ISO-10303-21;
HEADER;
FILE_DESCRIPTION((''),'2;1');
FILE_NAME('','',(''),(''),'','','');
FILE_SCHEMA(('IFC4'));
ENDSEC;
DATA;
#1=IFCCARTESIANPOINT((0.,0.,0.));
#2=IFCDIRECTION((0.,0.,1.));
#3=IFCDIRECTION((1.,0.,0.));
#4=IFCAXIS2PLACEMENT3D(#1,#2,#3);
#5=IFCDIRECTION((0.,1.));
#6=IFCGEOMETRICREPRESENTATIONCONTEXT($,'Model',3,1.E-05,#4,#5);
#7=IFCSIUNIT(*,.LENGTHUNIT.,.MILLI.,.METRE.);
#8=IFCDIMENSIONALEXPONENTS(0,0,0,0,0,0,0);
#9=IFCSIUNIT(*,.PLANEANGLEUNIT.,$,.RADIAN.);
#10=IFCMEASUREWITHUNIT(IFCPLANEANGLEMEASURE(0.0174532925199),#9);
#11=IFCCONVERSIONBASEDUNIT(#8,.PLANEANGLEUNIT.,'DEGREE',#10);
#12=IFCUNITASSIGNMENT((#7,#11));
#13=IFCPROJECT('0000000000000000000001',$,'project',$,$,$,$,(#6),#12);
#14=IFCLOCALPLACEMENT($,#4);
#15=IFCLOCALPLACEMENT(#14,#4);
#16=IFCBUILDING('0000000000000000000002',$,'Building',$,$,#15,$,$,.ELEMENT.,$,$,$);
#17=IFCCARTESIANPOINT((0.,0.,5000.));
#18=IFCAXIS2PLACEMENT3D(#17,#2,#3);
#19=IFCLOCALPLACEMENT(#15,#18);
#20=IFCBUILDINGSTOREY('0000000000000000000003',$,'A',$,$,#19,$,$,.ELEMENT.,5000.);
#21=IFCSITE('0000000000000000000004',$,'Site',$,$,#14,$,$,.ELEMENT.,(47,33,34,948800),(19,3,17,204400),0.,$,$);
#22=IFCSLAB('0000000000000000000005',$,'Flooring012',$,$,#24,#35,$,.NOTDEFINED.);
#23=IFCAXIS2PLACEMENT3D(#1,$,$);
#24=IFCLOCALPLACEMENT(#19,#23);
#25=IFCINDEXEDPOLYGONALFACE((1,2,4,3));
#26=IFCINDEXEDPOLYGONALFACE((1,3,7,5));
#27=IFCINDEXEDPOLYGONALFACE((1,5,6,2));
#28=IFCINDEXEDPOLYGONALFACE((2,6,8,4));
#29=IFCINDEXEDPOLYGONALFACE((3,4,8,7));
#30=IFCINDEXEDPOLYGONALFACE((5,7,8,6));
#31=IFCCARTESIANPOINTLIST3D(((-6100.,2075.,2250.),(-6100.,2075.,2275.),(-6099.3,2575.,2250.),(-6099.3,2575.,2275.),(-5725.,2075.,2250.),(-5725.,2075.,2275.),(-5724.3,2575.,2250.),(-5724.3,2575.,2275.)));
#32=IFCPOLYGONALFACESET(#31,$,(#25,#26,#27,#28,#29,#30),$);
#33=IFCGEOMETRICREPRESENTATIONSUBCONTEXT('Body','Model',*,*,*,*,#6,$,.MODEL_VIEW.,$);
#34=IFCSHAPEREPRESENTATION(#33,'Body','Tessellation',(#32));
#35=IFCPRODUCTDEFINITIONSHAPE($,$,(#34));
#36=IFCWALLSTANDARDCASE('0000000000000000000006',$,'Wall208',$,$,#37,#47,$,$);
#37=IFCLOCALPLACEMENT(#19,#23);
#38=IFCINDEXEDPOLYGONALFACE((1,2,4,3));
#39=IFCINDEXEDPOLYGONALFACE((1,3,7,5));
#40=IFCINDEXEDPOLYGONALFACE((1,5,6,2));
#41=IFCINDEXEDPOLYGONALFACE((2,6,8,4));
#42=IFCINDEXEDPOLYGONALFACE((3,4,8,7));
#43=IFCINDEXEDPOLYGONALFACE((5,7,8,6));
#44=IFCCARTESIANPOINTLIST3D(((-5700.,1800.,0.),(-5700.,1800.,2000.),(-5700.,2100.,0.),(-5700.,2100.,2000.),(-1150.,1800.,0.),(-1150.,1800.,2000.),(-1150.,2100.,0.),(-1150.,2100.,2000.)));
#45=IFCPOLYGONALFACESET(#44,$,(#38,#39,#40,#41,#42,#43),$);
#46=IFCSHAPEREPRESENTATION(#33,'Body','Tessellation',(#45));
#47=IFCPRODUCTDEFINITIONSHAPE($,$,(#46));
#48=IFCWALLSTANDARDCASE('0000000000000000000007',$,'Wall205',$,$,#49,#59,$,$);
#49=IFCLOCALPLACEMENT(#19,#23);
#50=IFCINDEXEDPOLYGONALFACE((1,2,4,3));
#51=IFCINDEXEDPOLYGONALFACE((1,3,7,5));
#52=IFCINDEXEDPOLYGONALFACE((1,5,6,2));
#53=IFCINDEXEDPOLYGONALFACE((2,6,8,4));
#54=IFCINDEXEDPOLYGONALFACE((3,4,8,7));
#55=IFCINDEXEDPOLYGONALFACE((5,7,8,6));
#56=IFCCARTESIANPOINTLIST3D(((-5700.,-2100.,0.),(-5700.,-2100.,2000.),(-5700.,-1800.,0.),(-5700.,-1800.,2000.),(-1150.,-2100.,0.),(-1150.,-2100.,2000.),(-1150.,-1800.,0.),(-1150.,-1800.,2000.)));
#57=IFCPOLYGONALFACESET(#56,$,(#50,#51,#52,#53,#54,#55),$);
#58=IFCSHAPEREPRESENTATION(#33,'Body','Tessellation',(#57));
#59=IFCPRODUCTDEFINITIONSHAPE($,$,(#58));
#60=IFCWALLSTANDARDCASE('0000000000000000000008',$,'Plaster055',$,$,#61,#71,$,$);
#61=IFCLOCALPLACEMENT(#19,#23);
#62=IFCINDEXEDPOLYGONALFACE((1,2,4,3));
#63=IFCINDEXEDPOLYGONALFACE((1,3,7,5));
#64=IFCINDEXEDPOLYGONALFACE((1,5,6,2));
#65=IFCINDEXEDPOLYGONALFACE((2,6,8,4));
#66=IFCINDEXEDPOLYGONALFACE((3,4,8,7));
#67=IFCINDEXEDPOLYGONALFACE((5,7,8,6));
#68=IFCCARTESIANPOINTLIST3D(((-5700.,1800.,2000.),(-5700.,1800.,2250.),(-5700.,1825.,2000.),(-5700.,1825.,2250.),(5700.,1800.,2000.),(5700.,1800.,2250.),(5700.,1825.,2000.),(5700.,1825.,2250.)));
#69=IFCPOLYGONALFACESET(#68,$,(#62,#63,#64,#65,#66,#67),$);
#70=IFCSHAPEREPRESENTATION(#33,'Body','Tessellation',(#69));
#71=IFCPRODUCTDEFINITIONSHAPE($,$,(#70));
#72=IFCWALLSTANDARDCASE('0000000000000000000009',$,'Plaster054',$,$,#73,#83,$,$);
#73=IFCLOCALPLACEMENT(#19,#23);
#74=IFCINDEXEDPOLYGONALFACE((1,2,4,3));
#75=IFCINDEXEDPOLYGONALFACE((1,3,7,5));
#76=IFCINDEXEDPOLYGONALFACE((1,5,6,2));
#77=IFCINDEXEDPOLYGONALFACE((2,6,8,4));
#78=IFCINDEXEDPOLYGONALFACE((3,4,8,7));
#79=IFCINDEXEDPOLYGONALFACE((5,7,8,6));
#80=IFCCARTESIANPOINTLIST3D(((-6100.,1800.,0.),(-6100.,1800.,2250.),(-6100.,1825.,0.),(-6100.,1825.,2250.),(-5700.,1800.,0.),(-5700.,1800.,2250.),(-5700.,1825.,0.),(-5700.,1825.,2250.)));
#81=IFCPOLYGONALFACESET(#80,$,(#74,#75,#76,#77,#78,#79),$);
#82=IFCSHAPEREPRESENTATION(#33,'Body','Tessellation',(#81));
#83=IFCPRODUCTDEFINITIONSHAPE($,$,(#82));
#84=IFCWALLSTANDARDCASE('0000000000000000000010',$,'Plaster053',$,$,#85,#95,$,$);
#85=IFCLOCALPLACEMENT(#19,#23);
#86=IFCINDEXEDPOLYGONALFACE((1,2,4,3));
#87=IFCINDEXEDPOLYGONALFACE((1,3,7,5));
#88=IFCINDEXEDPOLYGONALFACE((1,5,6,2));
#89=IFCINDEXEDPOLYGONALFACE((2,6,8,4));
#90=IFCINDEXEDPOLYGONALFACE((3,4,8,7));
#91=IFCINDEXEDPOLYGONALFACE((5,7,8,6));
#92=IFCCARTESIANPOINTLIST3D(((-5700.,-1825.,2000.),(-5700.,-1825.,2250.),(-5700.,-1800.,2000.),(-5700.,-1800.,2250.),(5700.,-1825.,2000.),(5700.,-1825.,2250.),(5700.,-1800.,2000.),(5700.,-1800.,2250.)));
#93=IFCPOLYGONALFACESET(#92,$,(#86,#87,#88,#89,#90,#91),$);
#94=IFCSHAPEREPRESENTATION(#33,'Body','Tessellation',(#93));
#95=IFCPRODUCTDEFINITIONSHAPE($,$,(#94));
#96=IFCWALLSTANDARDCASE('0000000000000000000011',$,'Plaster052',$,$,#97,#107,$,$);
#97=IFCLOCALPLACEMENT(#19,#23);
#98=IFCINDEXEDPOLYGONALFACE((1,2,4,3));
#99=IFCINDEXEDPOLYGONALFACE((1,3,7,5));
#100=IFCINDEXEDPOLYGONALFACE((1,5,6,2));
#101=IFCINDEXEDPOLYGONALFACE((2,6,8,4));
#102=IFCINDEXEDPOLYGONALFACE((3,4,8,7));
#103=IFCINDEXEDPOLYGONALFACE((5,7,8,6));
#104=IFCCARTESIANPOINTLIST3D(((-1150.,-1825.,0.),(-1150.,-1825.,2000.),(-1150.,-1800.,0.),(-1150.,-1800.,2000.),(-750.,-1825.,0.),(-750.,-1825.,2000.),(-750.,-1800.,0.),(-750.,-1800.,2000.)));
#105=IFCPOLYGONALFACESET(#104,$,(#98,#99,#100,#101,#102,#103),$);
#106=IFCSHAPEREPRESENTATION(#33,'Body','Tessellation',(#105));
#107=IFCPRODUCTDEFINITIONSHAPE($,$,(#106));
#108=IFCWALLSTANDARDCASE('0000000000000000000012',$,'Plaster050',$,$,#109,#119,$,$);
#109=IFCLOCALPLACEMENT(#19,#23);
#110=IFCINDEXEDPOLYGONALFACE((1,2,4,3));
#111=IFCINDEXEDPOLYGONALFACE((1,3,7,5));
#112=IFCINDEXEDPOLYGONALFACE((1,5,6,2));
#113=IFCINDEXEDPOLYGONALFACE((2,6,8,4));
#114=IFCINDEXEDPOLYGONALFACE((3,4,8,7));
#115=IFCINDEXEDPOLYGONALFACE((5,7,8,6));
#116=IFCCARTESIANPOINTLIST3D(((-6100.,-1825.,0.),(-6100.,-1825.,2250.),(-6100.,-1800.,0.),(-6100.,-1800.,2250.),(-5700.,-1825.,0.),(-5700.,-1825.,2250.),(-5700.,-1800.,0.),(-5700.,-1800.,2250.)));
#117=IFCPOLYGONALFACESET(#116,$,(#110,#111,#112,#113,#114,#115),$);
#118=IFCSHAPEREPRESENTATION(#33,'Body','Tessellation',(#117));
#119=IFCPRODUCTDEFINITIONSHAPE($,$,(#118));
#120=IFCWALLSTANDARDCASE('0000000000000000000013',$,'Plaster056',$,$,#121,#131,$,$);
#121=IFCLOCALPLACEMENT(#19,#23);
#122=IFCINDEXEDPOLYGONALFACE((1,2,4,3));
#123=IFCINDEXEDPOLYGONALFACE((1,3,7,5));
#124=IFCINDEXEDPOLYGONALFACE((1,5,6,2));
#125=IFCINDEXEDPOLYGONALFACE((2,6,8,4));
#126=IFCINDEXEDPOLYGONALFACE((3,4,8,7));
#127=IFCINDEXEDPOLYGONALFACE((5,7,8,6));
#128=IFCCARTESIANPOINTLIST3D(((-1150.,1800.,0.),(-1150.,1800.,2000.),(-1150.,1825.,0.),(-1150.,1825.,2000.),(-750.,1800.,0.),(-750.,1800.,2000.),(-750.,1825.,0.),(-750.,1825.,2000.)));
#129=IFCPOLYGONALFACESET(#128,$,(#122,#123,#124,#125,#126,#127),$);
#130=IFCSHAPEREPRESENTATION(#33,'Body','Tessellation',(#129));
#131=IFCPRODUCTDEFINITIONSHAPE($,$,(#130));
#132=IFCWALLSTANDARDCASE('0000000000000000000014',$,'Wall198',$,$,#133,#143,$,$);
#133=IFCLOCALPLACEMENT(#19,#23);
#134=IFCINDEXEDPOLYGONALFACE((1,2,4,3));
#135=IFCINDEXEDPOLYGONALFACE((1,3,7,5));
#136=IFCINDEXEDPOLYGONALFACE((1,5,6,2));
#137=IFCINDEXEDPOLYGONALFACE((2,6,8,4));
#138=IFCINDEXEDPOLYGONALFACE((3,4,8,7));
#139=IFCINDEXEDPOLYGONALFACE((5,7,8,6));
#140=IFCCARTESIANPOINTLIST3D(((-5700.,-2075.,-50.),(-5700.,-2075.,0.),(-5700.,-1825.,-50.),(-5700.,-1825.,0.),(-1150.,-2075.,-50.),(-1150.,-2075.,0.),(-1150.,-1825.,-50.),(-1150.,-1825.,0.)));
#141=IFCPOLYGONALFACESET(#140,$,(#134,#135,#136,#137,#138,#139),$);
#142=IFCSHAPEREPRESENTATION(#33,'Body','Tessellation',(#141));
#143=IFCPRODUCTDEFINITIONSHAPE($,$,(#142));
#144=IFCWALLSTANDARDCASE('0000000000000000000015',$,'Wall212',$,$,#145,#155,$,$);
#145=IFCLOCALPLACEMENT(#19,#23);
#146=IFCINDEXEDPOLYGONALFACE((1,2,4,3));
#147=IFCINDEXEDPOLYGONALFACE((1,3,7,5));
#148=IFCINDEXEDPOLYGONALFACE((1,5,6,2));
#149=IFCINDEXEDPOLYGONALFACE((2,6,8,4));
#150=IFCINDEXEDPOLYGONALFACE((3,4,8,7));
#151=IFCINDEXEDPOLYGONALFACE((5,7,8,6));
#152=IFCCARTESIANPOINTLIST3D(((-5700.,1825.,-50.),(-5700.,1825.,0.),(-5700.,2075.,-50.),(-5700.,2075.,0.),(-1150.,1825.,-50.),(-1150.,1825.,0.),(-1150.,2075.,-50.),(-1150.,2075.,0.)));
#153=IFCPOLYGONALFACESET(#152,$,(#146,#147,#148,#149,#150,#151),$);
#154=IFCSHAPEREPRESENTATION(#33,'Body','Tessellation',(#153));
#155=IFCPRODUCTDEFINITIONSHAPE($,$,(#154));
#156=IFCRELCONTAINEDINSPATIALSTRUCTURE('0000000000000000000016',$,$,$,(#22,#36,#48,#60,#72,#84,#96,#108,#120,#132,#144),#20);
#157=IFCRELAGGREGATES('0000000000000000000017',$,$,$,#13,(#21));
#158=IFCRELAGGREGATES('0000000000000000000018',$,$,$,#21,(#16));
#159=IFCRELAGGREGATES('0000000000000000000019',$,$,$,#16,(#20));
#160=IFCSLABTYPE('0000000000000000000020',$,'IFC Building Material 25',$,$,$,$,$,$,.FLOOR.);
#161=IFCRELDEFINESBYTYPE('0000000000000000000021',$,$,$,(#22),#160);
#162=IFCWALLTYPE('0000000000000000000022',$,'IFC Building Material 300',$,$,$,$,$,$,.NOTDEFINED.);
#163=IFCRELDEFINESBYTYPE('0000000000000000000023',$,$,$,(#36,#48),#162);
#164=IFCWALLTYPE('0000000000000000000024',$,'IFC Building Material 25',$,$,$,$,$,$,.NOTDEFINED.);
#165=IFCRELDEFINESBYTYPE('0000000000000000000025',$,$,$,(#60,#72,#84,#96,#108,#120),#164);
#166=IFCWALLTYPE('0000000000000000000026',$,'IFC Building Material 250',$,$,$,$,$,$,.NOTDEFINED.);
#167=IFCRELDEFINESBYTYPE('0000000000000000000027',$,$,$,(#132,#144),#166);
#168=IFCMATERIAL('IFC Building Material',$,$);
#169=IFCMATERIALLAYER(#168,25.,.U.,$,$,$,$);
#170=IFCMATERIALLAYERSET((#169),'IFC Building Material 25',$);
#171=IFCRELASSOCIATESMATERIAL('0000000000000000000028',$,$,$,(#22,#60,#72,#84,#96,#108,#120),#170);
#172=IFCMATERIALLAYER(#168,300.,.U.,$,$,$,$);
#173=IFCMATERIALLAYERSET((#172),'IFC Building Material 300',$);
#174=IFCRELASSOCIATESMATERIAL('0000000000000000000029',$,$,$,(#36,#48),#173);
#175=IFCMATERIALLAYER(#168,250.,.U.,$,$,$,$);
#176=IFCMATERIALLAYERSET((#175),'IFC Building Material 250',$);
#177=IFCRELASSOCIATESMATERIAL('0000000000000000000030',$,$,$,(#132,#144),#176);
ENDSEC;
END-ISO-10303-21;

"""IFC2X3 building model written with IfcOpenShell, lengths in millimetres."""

from ifc_helpers import new_model, entity, si_unit, converted_unit, direction, frame, origin_with_axes, place, context, subcontext, project, spatial, polyline, outline, extrude, material, layer, layer_set, layer_usage, type_object, element, save


model = new_model("IFC2X3")

# Units and contexts
model_context = context("Model", 3, precision=1e-05, world=origin_with_axes(), true_north=direction((0.0, 1.0)))
body_context = subcontext(model_context, "Body", "Model", "MODEL_VIEW")
ifc_project = project(units=[si_unit("LENGTHUNIT", "METRE", prefix="MILLI"), converted_unit("PLANEANGLEUNIT", "DEGREE", entity("IfcPlaneAngleMeasure", 0.0174532925199), si_unit("PLANEANGLEUNIT", "RADIAN"), dimensions=[0, 0, 0, 0, 0, 0, 0])], contexts=[model_context])

# Site, building, storey
site_placement = place(None, origin_with_axes())
site = spatial("IfcSite", under=ifc_project, at=site_placement, Name="Site", CompositionType="ELEMENT", RefLatitude=(47, 33, 34, 948800), RefLongitude=(19, 3, 17, 204400), RefElevation=0.0)
building_placement = place(site_placement, origin_with_axes())
building = spatial("IfcBuilding", under=site, at=building_placement, Name="Building", CompositionType="ELEMENT")
storey_placement = place(building_placement, frame((0.0, 0.0, 5000.0), z_axis=(0.0, 0.0, 1.0), x_axis=(1.0, 0.0, 0.0)))
storey = spatial("IfcBuildingStorey", under=building, at=storey_placement, Name="A", CompositionType="ELEMENT", Elevation=5000.0)

# Shared definitions
ifc_material = material(Name="IFC Building Material")

# Slab
ifc_layer_1 = layer(ifc_material, 250.0, ventilated="UNKNOWN")
ifc_layer_set_1 = layer_set([ifc_layer_1], Name="IFC Building Material 250")
ifc_layer_2 = layer(ifc_material, 25.0, ventilated="UNKNOWN")
ifc_layer_set_2 = layer_set([ifc_layer_2], Name="IFC Building Material 25")
slab_type_1 = type_object("IfcSlabType", Name="IFC Building Material 25", PredefinedType="FLOOR")
ifc_layer_usage_1 = layer_usage(ifc_layer_set_2, "AXIS3", "NEGATIVE", 25.0)
slab_1_placement = place(storey_placement, frame((-6099.3, 2575.0, 2275.0), z_axis=(0.0, 0.0, 1.0), x_axis=(1.0, 0.0, 0.0)))
element("IfcSlab", 1, at=slab_1_placement, inside=storey, type_object=slab_type_1, material=ifc_layer_usage_1, Name="Flooring012", PredefinedType="NOTDEFINED", context=body_context, shape_type="SweptSolid", body=[
    extrude(outline(polyline([(0.0, 0.0), (-0.7, -500.0), (374.3, -500.0), (375.0, 0.0), (0.0, 0.0)])), frame((0.0, 0.0, -25.0), z_axis=(0.0, 0.0, 1.0), x_axis=(1.0, 0.0, 0.0)), (0.0, 0.0, 1.0), 25.0),
])

# Walls
ifc_layer_3 = layer(ifc_material, 300.0, ventilated="UNKNOWN")
ifc_layer_set_3 = layer_set([ifc_layer_3], Name="IFC Building Material 300")
ifc_layer_usage_2 = layer_usage(ifc_layer_set_3, "AXIS2", "NEGATIVE", 0.0)
wall_type_1 = type_object("IfcWallType", Name="IFC Building Material 300", PredefinedType="NOTDEFINED")
wall_1_placement = place(storey_placement, frame((-1150.0, 1800.0, 0.0), z_axis=(0.0, 0.0, 1.0), x_axis=(-1.0, 0.0, 0.0)))
element("IfcWallStandardCase", 2, at=wall_1_placement, inside=storey, type_object=wall_type_1, material=ifc_layer_usage_2, Name="Wall208", context=body_context, shape_type="SweptSolid", body=[
    extrude(outline(polyline([(0.0, -300.0), (4550.0, -300.0), (4550.0, 0.0), (0.0, 0.0), (0.0, -300.0)])), origin_with_axes(), (0.0, 0.0, 1.0), 2000.0),
])
ifc_layer_usage_3 = layer_usage(ifc_layer_set_3, "AXIS2", "NEGATIVE", 300.0)
wall_2_placement = place(storey_placement, frame((-1150.0, -1800.0, 0.0), z_axis=(0.0, 0.0, 1.0), x_axis=(-1.0, 0.0, 0.0)))
element("IfcWallStandardCase", 3, at=wall_2_placement, inside=storey, type_object=wall_type_1, material=ifc_layer_usage_3, Name="Wall205", context=body_context, shape_type="SweptSolid", body=[
    extrude(outline(polyline([(0.0, 0.0), (4550.0, 0.0), (4550.0, 300.0), (0.0, 300.0), (0.0, 0.0)])), origin_with_axes(), (0.0, 0.0, 1.0), 2000.0),
])
ifc_layer_usage_4 = layer_usage(ifc_layer_set_2, "AXIS2", "POSITIVE", 0.0)
wall_type_2 = type_object("IfcWallType", Name="IFC Building Material 25", PredefinedType="NOTDEFINED")
wall_3_placement = place(storey_placement, frame((-5700.0, 1800.0, 2000.0), z_axis=(0.0, 0.0, 1.0), x_axis=(1.0, 0.0, 0.0)))
element("IfcWallStandardCase", 4, at=wall_3_placement, inside=storey, type_object=wall_type_2, material=ifc_layer_usage_4, Name="Plaster055", context=body_context, shape_type="SweptSolid", body=[
    extrude(outline(polyline([(0.0, 0.0), (11400.0, 0.0), (11400.0, 25.0), (0.0, 25.0), (0.0, 0.0)])), origin_with_axes(), (0.0, 0.0, 1.0), 250.0),
])
ifc_layer_usage_5 = layer_usage(ifc_layer_set_2, "AXIS2", "POSITIVE", 0.0)
wall_4_placement = place(storey_placement, frame((-6100.0, 1800.0, 0.0), z_axis=(0.0, 0.0, 1.0), x_axis=(1.0, 0.0, 0.0)))
element("IfcWallStandardCase", 5, at=wall_4_placement, inside=storey, type_object=wall_type_2, material=ifc_layer_usage_5, Name="Plaster054", context=body_context, shape_type="SweptSolid", body=[
    extrude(outline(polyline([(0.0, 0.0), (400.0, 0.0), (400.0, 25.0), (0.0, 25.0), (0.0, 0.0)])), origin_with_axes(), (0.0, 0.0, 1.0), 2250.0),
])
ifc_layer_usage_6 = layer_usage(ifc_layer_set_2, "AXIS2", "POSITIVE", -25.0)
wall_5_placement = place(storey_placement, frame((-5700.0, -1800.0, 2000.0), z_axis=(0.0, 0.0, 1.0), x_axis=(1.0, 0.0, 0.0)))
element("IfcWallStandardCase", 6, at=wall_5_placement, inside=storey, type_object=wall_type_2, material=ifc_layer_usage_6, Name="Plaster053", context=body_context, shape_type="SweptSolid", body=[
    extrude(outline(polyline([(0.0, -25.0), (11400.0, -25.0), (11400.0, 0.0), (0.0, 0.0), (0.0, -25.0)])), origin_with_axes(), (0.0, 0.0, 1.0), 250.0),
])
ifc_layer_usage_7 = layer_usage(ifc_layer_set_2, "AXIS2", "POSITIVE", -25.0)
wall_6_placement = place(storey_placement, frame((-1150.0, -1800.0, 0.0), z_axis=(0.0, 0.0, 1.0), x_axis=(1.0, 0.0, 0.0)))
element("IfcWallStandardCase", 7, at=wall_6_placement, inside=storey, type_object=wall_type_2, material=ifc_layer_usage_7, Name="Plaster052", context=body_context, shape_type="SweptSolid", body=[
    extrude(outline(polyline([(0.0, -25.0), (400.0, -25.0), (400.0, 0.0), (0.0, 0.0), (0.0, -25.0)])), origin_with_axes(), (0.0, 0.0, 1.0), 2000.0),
])
ifc_layer_usage_8 = layer_usage(ifc_layer_set_2, "AXIS2", "POSITIVE", -25.0)
wall_7_placement = place(storey_placement, frame((-6100.0, -1800.0, 0.0), z_axis=(0.0, 0.0, 1.0), x_axis=(1.0, 0.0, 0.0)))
element("IfcWallStandardCase", 8, at=wall_7_placement, inside=storey, type_object=wall_type_2, material=ifc_layer_usage_8, Name="Plaster050", context=body_context, shape_type="SweptSolid", body=[
    extrude(outline(polyline([(0.0, -25.0), (400.0, -25.0), (400.0, 0.0), (0.0, 0.0), (0.0, -25.0)])), origin_with_axes(), (0.0, 0.0, 1.0), 2250.0),
])
ifc_layer_usage_9 = layer_usage(ifc_layer_set_2, "AXIS2", "POSITIVE", 0.0)
wall_8_placement = place(storey_placement, frame((-1150.0, 1800.0, 0.0), z_axis=(0.0, 0.0, 1.0), x_axis=(1.0, 0.0, 0.0)))
element("IfcWallStandardCase", 9, at=wall_8_placement, inside=storey, type_object=wall_type_2, material=ifc_layer_usage_9, Name="Plaster056", context=body_context, shape_type="SweptSolid", body=[
    extrude(outline(polyline([(0.0, 0.0), (400.0, 0.0), (400.0, 25.0), (0.0, 25.0), (0.0, 0.0)])), origin_with_axes(), (0.0, 0.0, 1.0), 2000.0),
])
ifc_layer_usage_10 = layer_usage(ifc_layer_set_1, "AXIS2", "POSITIVE", -250.0)
wall_type_3 = type_object("IfcWallType", Name="IFC Building Material 250", PredefinedType="NOTDEFINED")
wall_9_placement = place(storey_placement, frame((-1150.0, -2075.0, -50.0), z_axis=(0.0, 0.0, 1.0), x_axis=(-1.0, 0.0, 0.0)))
element("IfcWallStandardCase", 10, at=wall_9_placement, inside=storey, type_object=wall_type_3, material=ifc_layer_usage_10, Name="Wall198", context=body_context, shape_type="SweptSolid", body=[
    extrude(outline(polyline([(0.0, -250.0), (4550.0, -250.0), (4550.0, 0.0), (0.0, 0.0), (0.0, -250.0)])), origin_with_axes(), (0.0, 0.0, 1.0), 50.0),
])
ifc_layer_usage_11 = layer_usage(ifc_layer_set_1, "AXIS2", "POSITIVE", 0.0)
wall_10_placement = place(storey_placement, frame((-1150.0, 2075.0, -50.0), z_axis=(0.0, 0.0, 1.0), x_axis=(-1.0, 0.0, 0.0)))
element("IfcWallStandardCase", 11, at=wall_10_placement, inside=storey, type_object=wall_type_3, material=ifc_layer_usage_11, Name="Wall212", context=body_context, shape_type="SweptSolid", body=[
    extrude(outline(polyline([(0.0, 0.0), (4550.0, 0.0), (4550.0, 250.0), (0.0, 250.0), (0.0, 0.0)])), origin_with_axes(), (0.0, 0.0, 1.0), 50.0),
])

save(model, "model.ifc")
